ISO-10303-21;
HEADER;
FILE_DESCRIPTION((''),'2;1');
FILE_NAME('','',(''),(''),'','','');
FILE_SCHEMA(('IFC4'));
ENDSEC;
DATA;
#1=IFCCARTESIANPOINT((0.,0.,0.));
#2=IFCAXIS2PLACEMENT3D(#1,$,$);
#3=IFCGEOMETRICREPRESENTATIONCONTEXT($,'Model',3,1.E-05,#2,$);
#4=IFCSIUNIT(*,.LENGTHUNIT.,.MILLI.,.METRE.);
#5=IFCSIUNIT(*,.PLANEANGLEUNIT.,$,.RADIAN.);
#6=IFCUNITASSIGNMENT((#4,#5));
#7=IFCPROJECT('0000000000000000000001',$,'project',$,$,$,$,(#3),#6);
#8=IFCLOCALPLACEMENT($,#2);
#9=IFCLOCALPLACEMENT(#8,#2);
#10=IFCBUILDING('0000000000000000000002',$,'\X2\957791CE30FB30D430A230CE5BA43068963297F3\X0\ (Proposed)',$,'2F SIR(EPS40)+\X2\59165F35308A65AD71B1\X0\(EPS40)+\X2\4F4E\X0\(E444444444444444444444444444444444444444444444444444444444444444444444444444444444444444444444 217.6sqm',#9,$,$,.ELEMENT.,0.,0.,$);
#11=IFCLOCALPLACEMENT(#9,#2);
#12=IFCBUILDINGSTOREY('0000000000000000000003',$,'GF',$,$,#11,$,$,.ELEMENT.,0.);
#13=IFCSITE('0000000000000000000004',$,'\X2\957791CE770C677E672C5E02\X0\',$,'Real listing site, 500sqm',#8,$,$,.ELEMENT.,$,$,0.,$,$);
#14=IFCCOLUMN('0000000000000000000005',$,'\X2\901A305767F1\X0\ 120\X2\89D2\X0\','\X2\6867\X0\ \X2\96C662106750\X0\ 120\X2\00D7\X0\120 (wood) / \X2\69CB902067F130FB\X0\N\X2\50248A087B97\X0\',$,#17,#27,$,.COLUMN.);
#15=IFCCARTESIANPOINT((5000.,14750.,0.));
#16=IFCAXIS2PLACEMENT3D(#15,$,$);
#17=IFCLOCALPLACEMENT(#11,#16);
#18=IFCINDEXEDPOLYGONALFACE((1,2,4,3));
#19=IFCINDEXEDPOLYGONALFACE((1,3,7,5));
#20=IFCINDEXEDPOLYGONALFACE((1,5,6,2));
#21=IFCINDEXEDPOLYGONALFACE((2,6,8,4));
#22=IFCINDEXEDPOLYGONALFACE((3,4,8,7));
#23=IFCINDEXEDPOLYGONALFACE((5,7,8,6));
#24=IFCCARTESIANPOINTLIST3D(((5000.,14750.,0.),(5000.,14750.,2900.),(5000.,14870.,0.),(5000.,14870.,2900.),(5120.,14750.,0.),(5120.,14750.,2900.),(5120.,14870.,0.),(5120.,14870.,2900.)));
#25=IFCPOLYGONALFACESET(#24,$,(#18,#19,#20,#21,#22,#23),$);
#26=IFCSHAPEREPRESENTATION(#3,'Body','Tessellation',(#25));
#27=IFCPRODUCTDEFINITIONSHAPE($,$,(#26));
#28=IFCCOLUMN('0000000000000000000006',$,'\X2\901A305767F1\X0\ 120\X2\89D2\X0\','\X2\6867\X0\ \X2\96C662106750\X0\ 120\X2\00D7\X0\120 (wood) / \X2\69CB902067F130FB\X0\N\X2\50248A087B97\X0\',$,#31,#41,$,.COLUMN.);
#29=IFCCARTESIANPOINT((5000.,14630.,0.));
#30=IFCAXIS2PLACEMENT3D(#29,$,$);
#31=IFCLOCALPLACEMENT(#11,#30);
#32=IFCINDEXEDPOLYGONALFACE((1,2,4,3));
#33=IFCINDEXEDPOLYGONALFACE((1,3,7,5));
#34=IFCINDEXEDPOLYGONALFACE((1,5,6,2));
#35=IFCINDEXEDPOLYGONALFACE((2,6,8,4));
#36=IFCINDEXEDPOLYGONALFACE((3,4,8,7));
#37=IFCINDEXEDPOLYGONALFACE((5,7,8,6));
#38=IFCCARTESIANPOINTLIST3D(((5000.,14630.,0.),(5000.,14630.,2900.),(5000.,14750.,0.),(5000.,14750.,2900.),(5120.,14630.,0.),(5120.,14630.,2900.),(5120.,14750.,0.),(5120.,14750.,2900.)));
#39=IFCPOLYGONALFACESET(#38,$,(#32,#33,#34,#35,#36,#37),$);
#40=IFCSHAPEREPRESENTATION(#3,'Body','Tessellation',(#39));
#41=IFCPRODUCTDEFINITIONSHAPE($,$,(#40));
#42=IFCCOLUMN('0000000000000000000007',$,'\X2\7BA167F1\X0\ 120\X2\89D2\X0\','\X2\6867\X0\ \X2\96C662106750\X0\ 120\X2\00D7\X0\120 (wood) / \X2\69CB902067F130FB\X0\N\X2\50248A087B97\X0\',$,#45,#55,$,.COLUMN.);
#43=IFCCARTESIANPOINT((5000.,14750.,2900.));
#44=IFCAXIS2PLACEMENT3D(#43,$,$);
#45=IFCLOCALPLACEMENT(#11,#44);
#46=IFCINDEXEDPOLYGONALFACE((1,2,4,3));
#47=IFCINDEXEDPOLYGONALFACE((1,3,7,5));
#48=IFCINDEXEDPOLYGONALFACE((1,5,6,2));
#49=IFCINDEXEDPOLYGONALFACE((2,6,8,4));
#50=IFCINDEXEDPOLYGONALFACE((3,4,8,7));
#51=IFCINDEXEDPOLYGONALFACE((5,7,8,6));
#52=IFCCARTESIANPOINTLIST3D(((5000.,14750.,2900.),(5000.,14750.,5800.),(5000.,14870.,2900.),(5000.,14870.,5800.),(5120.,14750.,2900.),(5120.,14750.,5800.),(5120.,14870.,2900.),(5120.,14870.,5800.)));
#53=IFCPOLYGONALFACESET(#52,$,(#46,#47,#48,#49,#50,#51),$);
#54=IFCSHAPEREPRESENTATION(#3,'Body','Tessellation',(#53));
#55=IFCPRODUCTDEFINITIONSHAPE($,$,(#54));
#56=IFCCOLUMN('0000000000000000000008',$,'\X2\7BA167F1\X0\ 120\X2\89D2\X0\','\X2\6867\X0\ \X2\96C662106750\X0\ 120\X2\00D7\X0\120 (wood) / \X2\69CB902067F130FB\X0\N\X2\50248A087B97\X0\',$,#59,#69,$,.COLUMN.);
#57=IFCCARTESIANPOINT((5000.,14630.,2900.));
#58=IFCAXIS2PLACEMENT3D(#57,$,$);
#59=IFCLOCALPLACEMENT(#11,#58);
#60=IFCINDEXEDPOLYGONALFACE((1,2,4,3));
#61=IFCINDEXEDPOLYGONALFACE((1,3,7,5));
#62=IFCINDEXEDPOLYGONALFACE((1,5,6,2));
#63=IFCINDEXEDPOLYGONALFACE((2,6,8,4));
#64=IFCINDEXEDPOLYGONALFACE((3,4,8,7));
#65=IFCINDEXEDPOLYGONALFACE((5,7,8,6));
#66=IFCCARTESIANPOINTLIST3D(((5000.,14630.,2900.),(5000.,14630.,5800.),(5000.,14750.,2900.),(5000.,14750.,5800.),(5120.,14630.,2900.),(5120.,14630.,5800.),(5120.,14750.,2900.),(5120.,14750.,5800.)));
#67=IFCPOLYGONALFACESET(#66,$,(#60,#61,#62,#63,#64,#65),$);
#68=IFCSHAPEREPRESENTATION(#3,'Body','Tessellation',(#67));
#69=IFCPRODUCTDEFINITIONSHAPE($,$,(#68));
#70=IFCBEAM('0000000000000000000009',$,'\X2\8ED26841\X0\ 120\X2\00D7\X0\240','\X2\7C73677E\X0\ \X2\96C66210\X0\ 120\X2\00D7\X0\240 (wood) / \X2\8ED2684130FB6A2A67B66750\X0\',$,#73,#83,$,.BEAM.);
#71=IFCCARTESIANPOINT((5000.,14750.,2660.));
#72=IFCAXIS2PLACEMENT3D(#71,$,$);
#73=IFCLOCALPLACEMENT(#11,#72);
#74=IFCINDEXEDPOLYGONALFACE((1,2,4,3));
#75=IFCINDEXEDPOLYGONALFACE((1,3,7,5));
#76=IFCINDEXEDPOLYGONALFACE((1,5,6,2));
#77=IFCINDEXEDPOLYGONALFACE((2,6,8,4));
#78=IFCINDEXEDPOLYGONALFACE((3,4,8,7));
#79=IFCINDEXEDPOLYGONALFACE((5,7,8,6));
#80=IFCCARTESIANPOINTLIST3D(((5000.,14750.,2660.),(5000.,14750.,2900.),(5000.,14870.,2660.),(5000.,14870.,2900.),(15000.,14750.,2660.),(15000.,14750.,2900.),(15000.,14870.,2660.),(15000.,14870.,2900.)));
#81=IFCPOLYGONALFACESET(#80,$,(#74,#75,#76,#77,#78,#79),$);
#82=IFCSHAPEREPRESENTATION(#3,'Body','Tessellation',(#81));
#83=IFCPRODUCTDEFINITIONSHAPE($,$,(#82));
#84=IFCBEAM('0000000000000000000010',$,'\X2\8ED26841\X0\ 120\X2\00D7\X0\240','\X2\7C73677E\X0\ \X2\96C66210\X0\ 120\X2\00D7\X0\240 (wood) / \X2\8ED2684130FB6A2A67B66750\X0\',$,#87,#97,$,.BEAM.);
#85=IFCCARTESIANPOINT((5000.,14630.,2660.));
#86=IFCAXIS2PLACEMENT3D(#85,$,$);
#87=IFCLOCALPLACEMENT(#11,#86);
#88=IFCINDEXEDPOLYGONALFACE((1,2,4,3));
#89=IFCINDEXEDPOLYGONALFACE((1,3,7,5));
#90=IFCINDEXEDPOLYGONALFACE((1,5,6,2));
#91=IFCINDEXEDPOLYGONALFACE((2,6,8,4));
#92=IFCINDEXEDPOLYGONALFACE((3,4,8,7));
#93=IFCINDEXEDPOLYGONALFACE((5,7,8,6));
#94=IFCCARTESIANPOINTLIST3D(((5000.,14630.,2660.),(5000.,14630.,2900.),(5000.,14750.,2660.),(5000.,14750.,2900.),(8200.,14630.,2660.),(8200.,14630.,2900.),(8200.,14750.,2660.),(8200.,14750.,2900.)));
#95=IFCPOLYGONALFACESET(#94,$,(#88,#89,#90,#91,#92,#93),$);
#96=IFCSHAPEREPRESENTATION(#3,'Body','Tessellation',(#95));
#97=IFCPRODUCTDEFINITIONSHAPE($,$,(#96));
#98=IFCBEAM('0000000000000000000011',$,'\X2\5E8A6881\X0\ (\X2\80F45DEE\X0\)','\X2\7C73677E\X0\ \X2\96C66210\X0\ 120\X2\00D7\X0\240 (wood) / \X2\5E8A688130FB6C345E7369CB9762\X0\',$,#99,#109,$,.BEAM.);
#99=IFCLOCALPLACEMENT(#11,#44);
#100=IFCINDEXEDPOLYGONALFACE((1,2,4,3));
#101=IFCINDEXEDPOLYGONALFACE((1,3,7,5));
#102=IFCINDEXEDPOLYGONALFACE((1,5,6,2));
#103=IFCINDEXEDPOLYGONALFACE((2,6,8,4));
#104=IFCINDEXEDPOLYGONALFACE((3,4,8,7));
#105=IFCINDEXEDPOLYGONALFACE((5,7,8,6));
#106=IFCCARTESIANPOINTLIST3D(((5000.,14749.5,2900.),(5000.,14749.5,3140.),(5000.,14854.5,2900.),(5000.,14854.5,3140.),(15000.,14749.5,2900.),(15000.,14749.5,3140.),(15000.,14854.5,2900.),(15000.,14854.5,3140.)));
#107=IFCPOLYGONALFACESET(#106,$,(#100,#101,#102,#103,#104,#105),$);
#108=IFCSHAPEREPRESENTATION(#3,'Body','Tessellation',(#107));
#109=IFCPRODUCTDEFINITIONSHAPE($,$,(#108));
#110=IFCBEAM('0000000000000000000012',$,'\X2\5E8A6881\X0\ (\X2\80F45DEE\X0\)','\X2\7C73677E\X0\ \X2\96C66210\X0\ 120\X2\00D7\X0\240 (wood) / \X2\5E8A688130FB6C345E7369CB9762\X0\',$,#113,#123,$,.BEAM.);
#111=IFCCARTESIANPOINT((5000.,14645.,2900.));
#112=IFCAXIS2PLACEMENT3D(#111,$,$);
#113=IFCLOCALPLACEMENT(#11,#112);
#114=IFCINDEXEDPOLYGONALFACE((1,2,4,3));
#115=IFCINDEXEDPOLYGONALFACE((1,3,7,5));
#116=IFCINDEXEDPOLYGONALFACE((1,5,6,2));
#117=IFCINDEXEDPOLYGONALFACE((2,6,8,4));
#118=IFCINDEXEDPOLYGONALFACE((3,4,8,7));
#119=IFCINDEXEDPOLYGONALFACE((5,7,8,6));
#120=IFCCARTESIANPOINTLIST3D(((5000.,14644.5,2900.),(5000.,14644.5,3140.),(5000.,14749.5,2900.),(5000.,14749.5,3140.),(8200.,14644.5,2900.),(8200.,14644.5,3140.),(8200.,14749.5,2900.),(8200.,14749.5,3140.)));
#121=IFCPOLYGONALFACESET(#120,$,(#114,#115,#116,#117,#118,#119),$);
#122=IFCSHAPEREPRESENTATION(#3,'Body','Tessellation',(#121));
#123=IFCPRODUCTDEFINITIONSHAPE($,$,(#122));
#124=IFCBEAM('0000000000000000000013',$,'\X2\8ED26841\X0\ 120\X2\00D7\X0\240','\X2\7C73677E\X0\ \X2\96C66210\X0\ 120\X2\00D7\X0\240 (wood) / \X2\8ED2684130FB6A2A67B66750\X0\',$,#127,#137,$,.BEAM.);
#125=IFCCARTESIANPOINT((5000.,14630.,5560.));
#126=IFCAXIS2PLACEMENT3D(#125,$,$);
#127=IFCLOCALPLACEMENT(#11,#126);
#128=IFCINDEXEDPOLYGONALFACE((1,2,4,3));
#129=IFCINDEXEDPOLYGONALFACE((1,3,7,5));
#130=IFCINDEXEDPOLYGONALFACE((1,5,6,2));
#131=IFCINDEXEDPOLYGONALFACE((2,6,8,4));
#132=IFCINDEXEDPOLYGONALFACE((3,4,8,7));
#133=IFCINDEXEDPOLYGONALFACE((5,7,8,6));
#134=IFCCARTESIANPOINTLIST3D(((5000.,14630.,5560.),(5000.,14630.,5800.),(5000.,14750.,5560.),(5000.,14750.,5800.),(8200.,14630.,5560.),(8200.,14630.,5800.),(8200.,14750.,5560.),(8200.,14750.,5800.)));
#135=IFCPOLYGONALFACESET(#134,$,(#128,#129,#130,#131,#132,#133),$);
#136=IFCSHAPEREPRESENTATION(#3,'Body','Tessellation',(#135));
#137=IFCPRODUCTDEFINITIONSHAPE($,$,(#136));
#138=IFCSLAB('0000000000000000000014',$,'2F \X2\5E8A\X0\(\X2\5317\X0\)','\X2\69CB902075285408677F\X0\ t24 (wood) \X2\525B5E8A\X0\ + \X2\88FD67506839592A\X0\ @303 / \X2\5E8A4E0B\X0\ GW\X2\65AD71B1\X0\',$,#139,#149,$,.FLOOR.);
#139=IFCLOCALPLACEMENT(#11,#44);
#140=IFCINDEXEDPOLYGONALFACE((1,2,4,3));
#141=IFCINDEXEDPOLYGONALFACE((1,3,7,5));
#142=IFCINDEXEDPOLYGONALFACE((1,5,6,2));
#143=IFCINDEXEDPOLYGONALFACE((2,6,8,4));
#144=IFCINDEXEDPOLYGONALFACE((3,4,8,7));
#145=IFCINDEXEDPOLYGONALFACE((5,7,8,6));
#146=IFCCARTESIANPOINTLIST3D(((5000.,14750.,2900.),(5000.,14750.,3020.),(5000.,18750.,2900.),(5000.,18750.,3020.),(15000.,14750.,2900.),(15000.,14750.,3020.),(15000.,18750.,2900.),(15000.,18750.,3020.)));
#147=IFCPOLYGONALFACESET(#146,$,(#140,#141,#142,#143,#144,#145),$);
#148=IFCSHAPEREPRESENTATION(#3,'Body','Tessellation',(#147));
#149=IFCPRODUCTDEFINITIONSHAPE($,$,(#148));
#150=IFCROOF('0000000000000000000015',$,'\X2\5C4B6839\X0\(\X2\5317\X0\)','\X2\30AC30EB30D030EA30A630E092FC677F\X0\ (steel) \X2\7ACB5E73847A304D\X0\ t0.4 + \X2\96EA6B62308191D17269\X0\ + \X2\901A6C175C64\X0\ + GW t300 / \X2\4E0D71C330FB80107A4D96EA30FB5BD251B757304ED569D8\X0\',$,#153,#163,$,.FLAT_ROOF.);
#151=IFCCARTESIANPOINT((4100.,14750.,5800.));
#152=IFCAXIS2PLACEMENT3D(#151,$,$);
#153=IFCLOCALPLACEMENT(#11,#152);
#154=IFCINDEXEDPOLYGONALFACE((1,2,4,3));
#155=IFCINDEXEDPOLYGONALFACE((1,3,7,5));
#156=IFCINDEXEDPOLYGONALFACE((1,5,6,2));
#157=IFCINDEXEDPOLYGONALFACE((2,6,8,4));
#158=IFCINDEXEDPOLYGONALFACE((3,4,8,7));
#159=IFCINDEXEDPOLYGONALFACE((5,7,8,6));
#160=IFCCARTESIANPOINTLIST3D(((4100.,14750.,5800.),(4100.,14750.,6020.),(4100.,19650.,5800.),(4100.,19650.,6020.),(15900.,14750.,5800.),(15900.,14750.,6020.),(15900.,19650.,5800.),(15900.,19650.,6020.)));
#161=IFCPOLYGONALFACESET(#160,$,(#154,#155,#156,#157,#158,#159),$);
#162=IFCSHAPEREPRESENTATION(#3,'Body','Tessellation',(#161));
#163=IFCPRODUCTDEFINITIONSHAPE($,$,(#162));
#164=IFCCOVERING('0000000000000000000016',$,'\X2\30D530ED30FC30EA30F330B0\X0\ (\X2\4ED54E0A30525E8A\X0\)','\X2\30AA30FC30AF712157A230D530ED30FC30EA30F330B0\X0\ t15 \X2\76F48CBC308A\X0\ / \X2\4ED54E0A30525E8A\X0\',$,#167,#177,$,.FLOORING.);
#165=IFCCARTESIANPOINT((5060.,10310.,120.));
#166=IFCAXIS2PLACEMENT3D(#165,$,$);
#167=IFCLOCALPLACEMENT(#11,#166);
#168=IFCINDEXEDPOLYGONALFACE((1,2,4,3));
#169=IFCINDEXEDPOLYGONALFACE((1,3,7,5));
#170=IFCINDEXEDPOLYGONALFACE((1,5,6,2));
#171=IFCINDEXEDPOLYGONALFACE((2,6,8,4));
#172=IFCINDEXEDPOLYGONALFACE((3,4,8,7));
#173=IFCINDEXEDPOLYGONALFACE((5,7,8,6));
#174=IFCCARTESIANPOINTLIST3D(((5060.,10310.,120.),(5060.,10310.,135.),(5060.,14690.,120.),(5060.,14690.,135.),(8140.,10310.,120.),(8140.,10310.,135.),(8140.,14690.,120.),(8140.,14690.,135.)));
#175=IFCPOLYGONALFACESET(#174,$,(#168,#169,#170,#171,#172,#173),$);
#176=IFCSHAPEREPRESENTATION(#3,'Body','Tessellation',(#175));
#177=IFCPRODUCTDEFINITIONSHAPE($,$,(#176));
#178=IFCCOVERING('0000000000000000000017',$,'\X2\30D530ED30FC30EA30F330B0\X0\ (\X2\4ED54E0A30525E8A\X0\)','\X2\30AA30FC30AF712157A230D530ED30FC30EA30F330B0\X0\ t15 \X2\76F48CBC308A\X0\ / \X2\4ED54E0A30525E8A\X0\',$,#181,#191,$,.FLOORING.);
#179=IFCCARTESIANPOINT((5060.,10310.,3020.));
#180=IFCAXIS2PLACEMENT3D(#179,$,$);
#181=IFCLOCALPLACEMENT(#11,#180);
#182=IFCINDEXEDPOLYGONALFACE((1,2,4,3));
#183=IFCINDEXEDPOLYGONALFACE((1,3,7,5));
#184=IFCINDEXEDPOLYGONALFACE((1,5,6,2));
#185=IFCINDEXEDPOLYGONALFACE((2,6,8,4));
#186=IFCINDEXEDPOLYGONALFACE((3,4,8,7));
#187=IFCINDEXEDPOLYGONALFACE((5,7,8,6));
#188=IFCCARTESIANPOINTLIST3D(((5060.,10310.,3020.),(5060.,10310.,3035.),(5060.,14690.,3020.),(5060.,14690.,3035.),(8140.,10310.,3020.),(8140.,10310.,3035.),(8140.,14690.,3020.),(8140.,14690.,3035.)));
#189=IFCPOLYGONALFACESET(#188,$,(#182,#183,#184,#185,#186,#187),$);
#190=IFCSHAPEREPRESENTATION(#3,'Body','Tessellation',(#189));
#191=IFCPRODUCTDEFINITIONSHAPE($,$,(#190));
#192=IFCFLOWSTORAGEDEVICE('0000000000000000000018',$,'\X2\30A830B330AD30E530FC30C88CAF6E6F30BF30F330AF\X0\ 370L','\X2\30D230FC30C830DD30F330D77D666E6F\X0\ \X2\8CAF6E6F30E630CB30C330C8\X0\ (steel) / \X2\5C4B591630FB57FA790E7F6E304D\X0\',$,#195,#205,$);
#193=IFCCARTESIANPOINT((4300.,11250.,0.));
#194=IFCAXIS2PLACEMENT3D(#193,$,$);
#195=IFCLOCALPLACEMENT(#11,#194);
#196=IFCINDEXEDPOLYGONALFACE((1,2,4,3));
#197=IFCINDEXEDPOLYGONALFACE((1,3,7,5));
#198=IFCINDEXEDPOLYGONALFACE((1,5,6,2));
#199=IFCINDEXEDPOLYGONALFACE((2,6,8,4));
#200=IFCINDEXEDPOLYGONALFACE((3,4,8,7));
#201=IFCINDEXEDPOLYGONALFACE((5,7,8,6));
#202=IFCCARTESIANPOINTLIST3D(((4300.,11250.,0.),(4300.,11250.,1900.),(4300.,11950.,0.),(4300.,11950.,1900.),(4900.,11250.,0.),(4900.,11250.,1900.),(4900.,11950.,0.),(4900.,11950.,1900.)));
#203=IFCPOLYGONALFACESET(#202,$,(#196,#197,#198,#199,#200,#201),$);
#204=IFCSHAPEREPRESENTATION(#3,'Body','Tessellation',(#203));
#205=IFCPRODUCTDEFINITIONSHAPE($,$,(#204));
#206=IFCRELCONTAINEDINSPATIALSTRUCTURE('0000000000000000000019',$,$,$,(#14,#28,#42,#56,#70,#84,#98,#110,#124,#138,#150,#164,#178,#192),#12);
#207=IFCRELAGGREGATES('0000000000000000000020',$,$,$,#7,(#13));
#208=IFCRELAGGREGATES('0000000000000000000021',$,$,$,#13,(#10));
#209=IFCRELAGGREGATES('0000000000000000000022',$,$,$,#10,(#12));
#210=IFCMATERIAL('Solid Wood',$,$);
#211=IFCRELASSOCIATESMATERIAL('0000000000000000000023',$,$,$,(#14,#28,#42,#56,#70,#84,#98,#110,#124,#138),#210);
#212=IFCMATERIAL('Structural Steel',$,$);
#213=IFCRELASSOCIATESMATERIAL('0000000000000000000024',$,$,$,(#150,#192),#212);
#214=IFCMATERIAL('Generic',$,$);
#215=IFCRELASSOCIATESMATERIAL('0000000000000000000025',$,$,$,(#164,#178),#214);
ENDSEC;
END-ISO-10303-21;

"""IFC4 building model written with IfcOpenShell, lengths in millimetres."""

from ifc_helpers import new_model, si_unit, frame, frame_2d, origin, place, context, project, spatial, rectangle, extrude, material, element, save


model = new_model("IFC4")

# Units and contexts
model_context = context("Model", 3, precision=1e-05, world=origin())
ifc_project = project(units=[si_unit("LENGTHUNIT", "METRE", prefix="MILLI"), si_unit("PLANEANGLEUNIT", "RADIAN")], contexts=[model_context])

# Site, building, storey
site_placement = place(None, origin())
site = spatial("IfcSite", under=ifc_project, at=site_placement, Name="長野県松本市", ObjectType="Real listing site, 500sqm", CompositionType="ELEMENT", RefElevation=0.0)
building_placement = place(site_placement, origin())
building = spatial("IfcBuilding", under=site, at=building_placement, Name="長野・ピアノ室と防音 (Proposed)", ObjectType="2F SIR(EPS40)+外張り断熱(EPS40)+低(E444444444444444444444444444444444444444444444444444444444444444444444444444444444444444444444 217.6sqm", CompositionType="ELEMENT", ElevationOfRefHeight=0.0, ElevationOfTerrain=0.0)
storey_placement = place(building_placement, origin())
storey = spatial("IfcBuildingStorey", under=building, at=storey_placement, Name="GF", CompositionType="ELEMENT", Elevation=0.0)

# Columns
ifc_material_1 = material(Name="Solid Wood")
column_1_placement = place(storey_placement, frame((5000.0, 14750.0, 0.0)))
element("IfcColumn", 1, at=column_1_placement, inside=storey, material=ifc_material_1, Name="通し柱 120角", Description="桧 集成材 120×120 (wood) / 構造柱・N値計算", PredefinedType="COLUMN", context=model_context, shape_type="SweptSolid", body=[
    extrude(rectangle(XDim=120.0, YDim=120.0, at=frame_2d((60.0, 60.0))), frame((5000.0, 14750.0, 0.0)), (0.0, 0.0, 1.0), 2900.0),
])
column_2_placement = place(storey_placement, frame((5000.0, 14630.0, 0.0)))
element("IfcColumn", 2, at=column_2_placement, inside=storey, material=ifc_material_1, Name="通し柱 120角", Description="桧 集成材 120×120 (wood) / 構造柱・N値計算", PredefinedType="COLUMN", context=model_context, shape_type="SweptSolid", body=[
    extrude(rectangle(XDim=120.0, YDim=120.0, at=frame_2d((60.0, 60.0))), frame((5000.0, 14630.0, 0.0)), (0.0, 0.0, 1.0), 2900.0),
])
column_3_placement = place(storey_placement, frame((5000.0, 14750.0, 2900.0)))
element("IfcColumn", 3, at=column_3_placement, inside=storey, material=ifc_material_1, Name="管柱 120角", Description="桧 集成材 120×120 (wood) / 構造柱・N値計算", PredefinedType="COLUMN", context=model_context, shape_type="SweptSolid", body=[
    extrude(rectangle(XDim=120.0, YDim=120.0, at=frame_2d((60.0, 60.0))), frame((5000.0, 14750.0, 2900.0)), (0.0, 0.0, 1.0), 2900.0),
])
column_4_placement = place(storey_placement, frame((5000.0, 14630.0, 2900.0)))
element("IfcColumn", 4, at=column_4_placement, inside=storey, material=ifc_material_1, Name="管柱 120角", Description="桧 集成材 120×120 (wood) / 構造柱・N値計算", PredefinedType="COLUMN", context=model_context, shape_type="SweptSolid", body=[
    extrude(rectangle(XDim=120.0, YDim=120.0, at=frame_2d((60.0, 60.0))), frame((5000.0, 14630.0, 2900.0)), (0.0, 0.0, 1.0), 2900.0),
])

# Beams
beam_1_placement = place(storey_placement, frame((5000.0, 14750.0, 2660.0)))
element("IfcBeam", 5, at=beam_1_placement, inside=storey, material=ifc_material_1, Name="軒桁 120×240", Description="米松 集成 120×240 (wood) / 軒桁・横架材", PredefinedType="BEAM", context=model_context, shape_type="SweptSolid", body=[
    extrude(rectangle(XDim=10000.0, YDim=120.0, at=frame_2d((5000.0, 60.0))), frame((5000.0, 14750.0, 2660.0)), (0.0, 0.0, 1.0), 240.0),
])
beam_2_placement = place(storey_placement, frame((5000.0, 14630.0, 2660.0)))
element("IfcBeam", 6, at=beam_2_placement, inside=storey, material=ifc_material_1, Name="軒桁 120×240", Description="米松 集成 120×240 (wood) / 軒桁・横架材", PredefinedType="BEAM", context=model_context, shape_type="SweptSolid", body=[
    extrude(rectangle(XDim=3200.0, YDim=120.0, at=frame_2d((1600.0, 60.0))), frame((5000.0, 14630.0, 2660.0)), (0.0, 0.0, 1.0), 240.0),
])
beam_3_placement = place(storey_placement, frame((5000.0, 14750.0, 2900.0)))
element("IfcBeam", 7, at=beam_3_placement, inside=storey, material=ifc_material_1, Name="床梁 (胴差)", Description="米松 集成 120×240 (wood) / 床梁・水平構面", PredefinedType="BEAM", context=model_context, shape_type="SweptSolid", body=[
    extrude(rectangle(XDim=10000.0, YDim=105.0, at=frame_2d((5000.0, 52.0))), frame((5000.0, 14750.0, 2900.0)), (0.0, 0.0, 1.0), 240.0),
])
beam_4_placement = place(storey_placement, frame((5000.0, 14645.0, 2900.0)))
element("IfcBeam", 8, at=beam_4_placement, inside=storey, material=ifc_material_1, Name="床梁 (胴差)", Description="米松 集成 120×240 (wood) / 床梁・水平構面", PredefinedType="BEAM", context=model_context, shape_type="SweptSolid", body=[
    extrude(rectangle(XDim=3200.0, YDim=105.0, at=frame_2d((1600.0, 52.0))), frame((5000.0, 14645.0, 2900.0)), (0.0, 0.0, 1.0), 240.0),
])
beam_5_placement = place(storey_placement, frame((5000.0, 14630.0, 5560.0)))
element("IfcBeam", 9, at=beam_5_placement, inside=storey, material=ifc_material_1, Name="軒桁 120×240", Description="米松 集成 120×240 (wood) / 軒桁・横架材", PredefinedType="BEAM", context=model_context, shape_type="SweptSolid", body=[
    extrude(rectangle(XDim=3200.0, YDim=120.0, at=frame_2d((1600.0, 60.0))), frame((5000.0, 14630.0, 5560.0)), (0.0, 0.0, 1.0), 240.0),
])

# Slab
slab_1_placement = place(storey_placement, frame((5000.0, 14750.0, 2900.0)))
element("IfcSlab", 10, at=slab_1_placement, inside=storey, material=ifc_material_1, Name="2F 床(北)", Description="構造用合板 t24 (wood) 剛床 + 製材根太 @303 / 床下 GW断熱", PredefinedType="FLOOR", context=model_context, shape_type="SweptSolid", body=[
    extrude(rectangle(XDim=10000.0, YDim=4000.0, at=frame_2d((5000.0, 2000.0))), frame((5000.0, 14750.0, 2900.0)), (0.0, 0.0, 1.0), 120.0),
])

# Roof
ifc_material_2 = material(Name="Structural Steel")
for number, where, name in (
    (11, (4100.0, 14750.0, 5800.0), "屋根(北)"),
):
    element("IfcRoof", number, at=place(storey_placement, frame(where)), inside=storey, material=ifc_material_2, Name=name, Description="ガルバリウム鋼板 (steel) 立平葺き t0.4 + 雪止め金物 + 通気層 + GW t300 / 不燃・耐積雪・寒冷地仕様", PredefinedType="FLAT_ROOF", context=model_context, shape_type="SweptSolid", body=[
        extrude(rectangle(XDim=11800.0, YDim=4900.0, at=frame_2d((5900.0, 2450.0))), frame((4100.0, 14750.0, 5800.0)), (0.0, 0.0, 1.0), 220.0),
    ])

# Coverings
ifc_material_3 = material(Name="Generic")
covering_1_placement = place(storey_placement, frame((5060.0, 10310.0, 120.0)))
element("IfcCovering", 12, at=covering_1_placement, inside=storey, material=ifc_material_3, Name="フローリング (仕上げ床)", Description="オーク無垢フローリング t15 直貼り / 仕上げ床", PredefinedType="FLOORING", context=model_context, shape_type="SweptSolid", body=[
    extrude(rectangle(XDim=3080.0, YDim=4380.0, at=frame_2d((1540.0, 2190.0))), frame((5060.0, 10310.0, 120.0)), (0.0, 0.0, 1.0), 15.0),
])
covering_2_placement = place(storey_placement, frame((5060.0, 10310.0, 3020.0)))
element("IfcCovering", 13, at=covering_2_placement, inside=storey, material=ifc_material_3, Name="フローリング (仕上げ床)", Description="オーク無垢フローリング t15 直貼り / 仕上げ床", PredefinedType="FLOORING", context=model_context, shape_type="SweptSolid", body=[
    extrude(rectangle(XDim=3080.0, YDim=4380.0, at=frame_2d((1540.0, 2190.0))), frame((5060.0, 10310.0, 3020.0)), (0.0, 0.0, 1.0), 15.0),
])

# Flow storage device
flow_storage_device_placement = place(storey_placement, frame((4300.0, 11250.0, 0.0)))
element("IfcFlowStorageDevice", 14, at=flow_storage_device_placement, inside=storey, material=ifc_material_2, Name="エコキュート貯湯タンク 370L", Description="ヒートポンプ給湯 貯湯ユニット (steel) / 屋外・基礎置き", context=model_context, shape_type="SweptSolid", body=[
    extrude(rectangle(XDim=600.0, YDim=700.0, at=frame_2d((300.0, 350.0))), frame((4300.0, 11250.0, 0.0)), (0.0, 0.0, 1.0), 1900.0),
])

save(model, "model.ifc")
